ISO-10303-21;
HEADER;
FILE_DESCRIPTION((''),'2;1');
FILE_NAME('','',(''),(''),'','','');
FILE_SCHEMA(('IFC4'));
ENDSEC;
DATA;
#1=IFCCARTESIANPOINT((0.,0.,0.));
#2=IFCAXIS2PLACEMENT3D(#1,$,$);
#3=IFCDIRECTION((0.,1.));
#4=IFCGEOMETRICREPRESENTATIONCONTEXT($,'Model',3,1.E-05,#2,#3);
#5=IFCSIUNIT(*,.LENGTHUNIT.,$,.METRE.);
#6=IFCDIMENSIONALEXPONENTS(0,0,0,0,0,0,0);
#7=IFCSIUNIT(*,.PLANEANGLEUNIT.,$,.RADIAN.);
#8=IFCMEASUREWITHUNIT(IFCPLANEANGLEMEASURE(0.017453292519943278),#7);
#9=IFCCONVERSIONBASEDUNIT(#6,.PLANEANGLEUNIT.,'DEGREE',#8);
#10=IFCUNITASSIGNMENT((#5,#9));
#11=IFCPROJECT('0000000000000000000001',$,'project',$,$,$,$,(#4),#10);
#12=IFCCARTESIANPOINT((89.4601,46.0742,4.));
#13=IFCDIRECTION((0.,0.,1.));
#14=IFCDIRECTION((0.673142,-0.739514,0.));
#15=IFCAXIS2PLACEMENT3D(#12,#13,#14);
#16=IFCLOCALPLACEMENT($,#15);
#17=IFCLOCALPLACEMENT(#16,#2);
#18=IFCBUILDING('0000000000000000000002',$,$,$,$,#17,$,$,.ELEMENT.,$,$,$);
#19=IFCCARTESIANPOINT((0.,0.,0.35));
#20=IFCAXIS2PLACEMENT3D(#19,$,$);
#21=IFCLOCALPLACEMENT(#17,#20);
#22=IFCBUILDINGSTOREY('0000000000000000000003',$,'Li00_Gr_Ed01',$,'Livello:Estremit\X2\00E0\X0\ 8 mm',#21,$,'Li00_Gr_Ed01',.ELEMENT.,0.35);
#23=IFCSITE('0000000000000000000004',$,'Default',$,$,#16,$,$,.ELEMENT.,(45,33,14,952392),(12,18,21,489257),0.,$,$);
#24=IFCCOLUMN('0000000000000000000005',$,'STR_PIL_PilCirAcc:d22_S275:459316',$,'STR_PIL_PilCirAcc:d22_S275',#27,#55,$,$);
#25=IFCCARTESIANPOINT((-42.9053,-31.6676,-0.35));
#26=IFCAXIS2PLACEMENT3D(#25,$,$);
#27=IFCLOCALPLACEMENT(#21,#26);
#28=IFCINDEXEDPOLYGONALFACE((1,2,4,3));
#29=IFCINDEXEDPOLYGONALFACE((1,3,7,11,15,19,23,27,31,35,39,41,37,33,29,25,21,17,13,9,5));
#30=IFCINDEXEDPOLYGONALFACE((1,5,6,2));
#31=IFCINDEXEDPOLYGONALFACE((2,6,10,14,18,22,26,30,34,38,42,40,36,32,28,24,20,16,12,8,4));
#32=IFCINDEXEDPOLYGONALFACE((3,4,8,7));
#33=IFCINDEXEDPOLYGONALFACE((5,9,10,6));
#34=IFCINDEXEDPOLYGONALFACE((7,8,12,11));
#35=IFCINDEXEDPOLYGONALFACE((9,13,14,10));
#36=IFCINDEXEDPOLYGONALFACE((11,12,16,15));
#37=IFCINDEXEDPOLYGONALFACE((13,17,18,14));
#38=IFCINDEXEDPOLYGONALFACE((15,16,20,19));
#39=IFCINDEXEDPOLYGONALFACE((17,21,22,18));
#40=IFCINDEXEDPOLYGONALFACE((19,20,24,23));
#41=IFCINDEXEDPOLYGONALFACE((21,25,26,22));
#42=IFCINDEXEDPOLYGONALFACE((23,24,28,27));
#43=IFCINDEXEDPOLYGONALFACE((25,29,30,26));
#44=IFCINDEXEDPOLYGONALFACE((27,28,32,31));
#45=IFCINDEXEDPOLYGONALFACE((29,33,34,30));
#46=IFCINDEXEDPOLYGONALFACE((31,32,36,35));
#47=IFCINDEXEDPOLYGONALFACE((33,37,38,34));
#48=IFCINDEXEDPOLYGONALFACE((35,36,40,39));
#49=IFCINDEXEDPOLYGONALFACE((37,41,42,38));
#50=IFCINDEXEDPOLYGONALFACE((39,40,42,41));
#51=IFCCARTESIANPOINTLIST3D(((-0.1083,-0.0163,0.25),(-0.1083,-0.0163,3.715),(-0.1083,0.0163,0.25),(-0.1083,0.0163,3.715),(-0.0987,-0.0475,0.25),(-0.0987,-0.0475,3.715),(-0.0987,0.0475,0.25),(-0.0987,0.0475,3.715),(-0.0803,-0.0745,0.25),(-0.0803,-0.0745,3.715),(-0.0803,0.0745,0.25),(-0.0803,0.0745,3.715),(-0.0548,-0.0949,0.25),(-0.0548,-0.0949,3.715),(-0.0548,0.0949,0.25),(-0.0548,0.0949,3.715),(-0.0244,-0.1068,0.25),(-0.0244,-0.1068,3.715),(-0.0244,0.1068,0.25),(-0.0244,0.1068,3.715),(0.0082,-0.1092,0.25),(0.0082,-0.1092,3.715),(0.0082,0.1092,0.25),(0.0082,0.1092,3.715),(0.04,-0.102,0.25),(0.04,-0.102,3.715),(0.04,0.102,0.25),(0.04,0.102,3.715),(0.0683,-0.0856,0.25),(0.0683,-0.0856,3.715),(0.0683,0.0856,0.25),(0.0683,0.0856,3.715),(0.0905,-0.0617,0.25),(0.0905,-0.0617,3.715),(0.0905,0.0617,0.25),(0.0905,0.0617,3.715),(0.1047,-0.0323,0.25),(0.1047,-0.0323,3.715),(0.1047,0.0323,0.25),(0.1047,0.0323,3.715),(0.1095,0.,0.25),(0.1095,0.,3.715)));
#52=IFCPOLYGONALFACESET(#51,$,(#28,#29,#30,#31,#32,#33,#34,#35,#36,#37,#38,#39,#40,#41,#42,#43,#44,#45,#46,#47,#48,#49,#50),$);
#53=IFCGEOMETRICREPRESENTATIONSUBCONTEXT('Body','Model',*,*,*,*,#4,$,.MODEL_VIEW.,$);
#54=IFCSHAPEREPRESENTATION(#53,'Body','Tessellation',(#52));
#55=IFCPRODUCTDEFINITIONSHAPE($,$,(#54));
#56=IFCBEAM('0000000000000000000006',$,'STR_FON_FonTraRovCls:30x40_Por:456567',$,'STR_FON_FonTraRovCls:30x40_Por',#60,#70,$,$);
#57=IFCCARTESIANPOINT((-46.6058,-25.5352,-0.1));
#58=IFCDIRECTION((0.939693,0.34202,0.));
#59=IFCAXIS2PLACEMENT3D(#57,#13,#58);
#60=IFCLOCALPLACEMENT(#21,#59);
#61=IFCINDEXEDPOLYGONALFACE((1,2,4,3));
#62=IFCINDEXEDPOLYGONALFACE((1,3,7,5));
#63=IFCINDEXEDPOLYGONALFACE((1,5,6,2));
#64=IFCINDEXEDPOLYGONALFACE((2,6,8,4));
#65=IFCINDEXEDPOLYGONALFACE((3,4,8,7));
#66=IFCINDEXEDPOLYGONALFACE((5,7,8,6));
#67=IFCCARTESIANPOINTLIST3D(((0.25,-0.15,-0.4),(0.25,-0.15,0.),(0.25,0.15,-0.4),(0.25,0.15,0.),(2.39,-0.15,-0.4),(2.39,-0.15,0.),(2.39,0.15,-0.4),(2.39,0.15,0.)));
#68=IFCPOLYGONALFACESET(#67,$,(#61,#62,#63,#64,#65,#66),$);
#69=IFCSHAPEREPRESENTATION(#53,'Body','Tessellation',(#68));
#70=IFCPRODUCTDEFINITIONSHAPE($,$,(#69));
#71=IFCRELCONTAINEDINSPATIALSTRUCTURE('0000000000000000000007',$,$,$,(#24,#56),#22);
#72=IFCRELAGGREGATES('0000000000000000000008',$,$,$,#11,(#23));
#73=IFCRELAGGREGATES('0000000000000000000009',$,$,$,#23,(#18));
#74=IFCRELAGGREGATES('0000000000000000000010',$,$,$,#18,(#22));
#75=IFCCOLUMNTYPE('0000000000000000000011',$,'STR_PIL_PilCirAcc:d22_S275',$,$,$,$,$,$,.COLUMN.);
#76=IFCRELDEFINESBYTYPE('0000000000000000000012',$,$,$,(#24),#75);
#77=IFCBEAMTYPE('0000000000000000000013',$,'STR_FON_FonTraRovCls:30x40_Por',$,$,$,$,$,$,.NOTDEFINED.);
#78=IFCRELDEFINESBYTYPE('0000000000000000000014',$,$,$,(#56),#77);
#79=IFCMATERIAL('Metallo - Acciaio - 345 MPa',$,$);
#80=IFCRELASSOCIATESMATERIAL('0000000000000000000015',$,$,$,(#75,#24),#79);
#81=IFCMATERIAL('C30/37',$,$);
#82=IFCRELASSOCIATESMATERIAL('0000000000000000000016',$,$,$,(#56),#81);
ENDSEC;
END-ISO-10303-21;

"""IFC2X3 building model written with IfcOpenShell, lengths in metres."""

from ifc_helpers import new_model, entity, si_unit, converted_unit, direction, frame, frame_2d, origin, place, context, subcontext, project, spatial, rectangle, circle, extrude, source, transform, mapped, material, type_object, type_shapes, element, save


model = new_model("IFC2X3")

# Units and contexts
model_context = context("Model", 3, precision=1e-05, world=origin(), true_north=direction((0.0, 1.0)))
body_context = subcontext(model_context, "Body", "Model", "MODEL_VIEW")
ifc_project = project(units=[si_unit("LENGTHUNIT", "METRE"), converted_unit("PLANEANGLEUNIT", "DEGREE", entity("IfcPlaneAngleMeasure", 0.017453292519943278), si_unit("PLANEANGLEUNIT", "RADIAN"), dimensions=[0, 0, 0, 0, 0, 0, 0])], contexts=[model_context])

# Site, building, storey
site_placement = place(None, frame((89.4601, 46.0742, 4.0), z_axis=(0.0, 0.0, 1.0), x_axis=(0.673142, -0.739514, 0.0)))
site = spatial("IfcSite", under=ifc_project, at=site_placement, Name="Default", CompositionType="ELEMENT", RefLatitude=(45, 33, 14, 952392), RefLongitude=(12, 18, 21, 489257), RefElevation=0.0)
building_placement = place(site_placement, origin())
building = spatial("IfcBuilding", under=site, at=building_placement, CompositionType="ELEMENT")
storey_placement = place(building_placement, frame((0.0, 0.0, 0.35)))
storey = spatial("IfcBuildingStorey", under=building, at=storey_placement, Name="Li00_Gr_Ed01", ObjectType="Livello:Estremità 8 mm", LongName="Li00_Gr_Ed01", CompositionType="ELEMENT", Elevation=0.35)

# Column
ifc_material_1 = material(Name="Metallo - Acciaio - 345 MPa")
column_type = type_object("IfcColumnType", Name="STR_PIL_PilCirAcc:d22_S275", PredefinedType="COLUMN", material=ifc_material_1)
shared_shape = source(origin(), body_context, "Body", "SweptSolid", [
    extrude(circle(Radius=0.1096, at=frame_2d((0.0, 0.0), x_axis=(1.0, 0.0))), frame((0.0, 0.0, 0.25)), (0.0, 0.0, 1.0), 3.465),
])
type_shapes(column_type, [shared_shape])
column_1_placement = place(storey_placement, frame((-42.9053, -31.6676, -0.35)))
element("IfcColumn", 1, at=column_1_placement, inside=storey, type_object=column_type, material=ifc_material_1, Name="STR_PIL_PilCirAcc:d22_S275:459316", ObjectType="STR_PIL_PilCirAcc:d22_S275", context=body_context, shape_type="MappedRepresentation", body=[
    mapped(shared_shape, transform((0.0, 0.0, 0.0), scale=1.0)),
])

# Beam
ifc_material_2 = material(Name="C30/37")
beam_type_1 = type_object("IfcBeamType", Name="STR_FON_FonTraRovCls:30x40_Por", PredefinedType="NOTDEFINED")
beam_1_placement = place(storey_placement, frame((-46.6058, -25.5352, -0.1), z_axis=(0.0, 0.0, 1.0), x_axis=(0.939693, 0.34202, 0.0)))
element("IfcBeam", 2, at=beam_1_placement, inside=storey, type_object=beam_type_1, material=ifc_material_2, Name="STR_FON_FonTraRovCls:30x40_Por:456567", ObjectType="STR_FON_FonTraRovCls:30x40_Por", context=body_context, shape_type="SweptSolid", body=[
    extrude(rectangle(XDim=0.4, YDim=0.3, at=frame_2d((0.0, 0.0), x_axis=(1.0, 0.0))), frame((0.25, 0.0, -0.2), z_axis=(1.0, 0.0, 0.0), x_axis=(0.0, 0.0, -1.0)), (0.0, 0.0, 1.0), 2.14),
])

save(model, "model.ifc")
